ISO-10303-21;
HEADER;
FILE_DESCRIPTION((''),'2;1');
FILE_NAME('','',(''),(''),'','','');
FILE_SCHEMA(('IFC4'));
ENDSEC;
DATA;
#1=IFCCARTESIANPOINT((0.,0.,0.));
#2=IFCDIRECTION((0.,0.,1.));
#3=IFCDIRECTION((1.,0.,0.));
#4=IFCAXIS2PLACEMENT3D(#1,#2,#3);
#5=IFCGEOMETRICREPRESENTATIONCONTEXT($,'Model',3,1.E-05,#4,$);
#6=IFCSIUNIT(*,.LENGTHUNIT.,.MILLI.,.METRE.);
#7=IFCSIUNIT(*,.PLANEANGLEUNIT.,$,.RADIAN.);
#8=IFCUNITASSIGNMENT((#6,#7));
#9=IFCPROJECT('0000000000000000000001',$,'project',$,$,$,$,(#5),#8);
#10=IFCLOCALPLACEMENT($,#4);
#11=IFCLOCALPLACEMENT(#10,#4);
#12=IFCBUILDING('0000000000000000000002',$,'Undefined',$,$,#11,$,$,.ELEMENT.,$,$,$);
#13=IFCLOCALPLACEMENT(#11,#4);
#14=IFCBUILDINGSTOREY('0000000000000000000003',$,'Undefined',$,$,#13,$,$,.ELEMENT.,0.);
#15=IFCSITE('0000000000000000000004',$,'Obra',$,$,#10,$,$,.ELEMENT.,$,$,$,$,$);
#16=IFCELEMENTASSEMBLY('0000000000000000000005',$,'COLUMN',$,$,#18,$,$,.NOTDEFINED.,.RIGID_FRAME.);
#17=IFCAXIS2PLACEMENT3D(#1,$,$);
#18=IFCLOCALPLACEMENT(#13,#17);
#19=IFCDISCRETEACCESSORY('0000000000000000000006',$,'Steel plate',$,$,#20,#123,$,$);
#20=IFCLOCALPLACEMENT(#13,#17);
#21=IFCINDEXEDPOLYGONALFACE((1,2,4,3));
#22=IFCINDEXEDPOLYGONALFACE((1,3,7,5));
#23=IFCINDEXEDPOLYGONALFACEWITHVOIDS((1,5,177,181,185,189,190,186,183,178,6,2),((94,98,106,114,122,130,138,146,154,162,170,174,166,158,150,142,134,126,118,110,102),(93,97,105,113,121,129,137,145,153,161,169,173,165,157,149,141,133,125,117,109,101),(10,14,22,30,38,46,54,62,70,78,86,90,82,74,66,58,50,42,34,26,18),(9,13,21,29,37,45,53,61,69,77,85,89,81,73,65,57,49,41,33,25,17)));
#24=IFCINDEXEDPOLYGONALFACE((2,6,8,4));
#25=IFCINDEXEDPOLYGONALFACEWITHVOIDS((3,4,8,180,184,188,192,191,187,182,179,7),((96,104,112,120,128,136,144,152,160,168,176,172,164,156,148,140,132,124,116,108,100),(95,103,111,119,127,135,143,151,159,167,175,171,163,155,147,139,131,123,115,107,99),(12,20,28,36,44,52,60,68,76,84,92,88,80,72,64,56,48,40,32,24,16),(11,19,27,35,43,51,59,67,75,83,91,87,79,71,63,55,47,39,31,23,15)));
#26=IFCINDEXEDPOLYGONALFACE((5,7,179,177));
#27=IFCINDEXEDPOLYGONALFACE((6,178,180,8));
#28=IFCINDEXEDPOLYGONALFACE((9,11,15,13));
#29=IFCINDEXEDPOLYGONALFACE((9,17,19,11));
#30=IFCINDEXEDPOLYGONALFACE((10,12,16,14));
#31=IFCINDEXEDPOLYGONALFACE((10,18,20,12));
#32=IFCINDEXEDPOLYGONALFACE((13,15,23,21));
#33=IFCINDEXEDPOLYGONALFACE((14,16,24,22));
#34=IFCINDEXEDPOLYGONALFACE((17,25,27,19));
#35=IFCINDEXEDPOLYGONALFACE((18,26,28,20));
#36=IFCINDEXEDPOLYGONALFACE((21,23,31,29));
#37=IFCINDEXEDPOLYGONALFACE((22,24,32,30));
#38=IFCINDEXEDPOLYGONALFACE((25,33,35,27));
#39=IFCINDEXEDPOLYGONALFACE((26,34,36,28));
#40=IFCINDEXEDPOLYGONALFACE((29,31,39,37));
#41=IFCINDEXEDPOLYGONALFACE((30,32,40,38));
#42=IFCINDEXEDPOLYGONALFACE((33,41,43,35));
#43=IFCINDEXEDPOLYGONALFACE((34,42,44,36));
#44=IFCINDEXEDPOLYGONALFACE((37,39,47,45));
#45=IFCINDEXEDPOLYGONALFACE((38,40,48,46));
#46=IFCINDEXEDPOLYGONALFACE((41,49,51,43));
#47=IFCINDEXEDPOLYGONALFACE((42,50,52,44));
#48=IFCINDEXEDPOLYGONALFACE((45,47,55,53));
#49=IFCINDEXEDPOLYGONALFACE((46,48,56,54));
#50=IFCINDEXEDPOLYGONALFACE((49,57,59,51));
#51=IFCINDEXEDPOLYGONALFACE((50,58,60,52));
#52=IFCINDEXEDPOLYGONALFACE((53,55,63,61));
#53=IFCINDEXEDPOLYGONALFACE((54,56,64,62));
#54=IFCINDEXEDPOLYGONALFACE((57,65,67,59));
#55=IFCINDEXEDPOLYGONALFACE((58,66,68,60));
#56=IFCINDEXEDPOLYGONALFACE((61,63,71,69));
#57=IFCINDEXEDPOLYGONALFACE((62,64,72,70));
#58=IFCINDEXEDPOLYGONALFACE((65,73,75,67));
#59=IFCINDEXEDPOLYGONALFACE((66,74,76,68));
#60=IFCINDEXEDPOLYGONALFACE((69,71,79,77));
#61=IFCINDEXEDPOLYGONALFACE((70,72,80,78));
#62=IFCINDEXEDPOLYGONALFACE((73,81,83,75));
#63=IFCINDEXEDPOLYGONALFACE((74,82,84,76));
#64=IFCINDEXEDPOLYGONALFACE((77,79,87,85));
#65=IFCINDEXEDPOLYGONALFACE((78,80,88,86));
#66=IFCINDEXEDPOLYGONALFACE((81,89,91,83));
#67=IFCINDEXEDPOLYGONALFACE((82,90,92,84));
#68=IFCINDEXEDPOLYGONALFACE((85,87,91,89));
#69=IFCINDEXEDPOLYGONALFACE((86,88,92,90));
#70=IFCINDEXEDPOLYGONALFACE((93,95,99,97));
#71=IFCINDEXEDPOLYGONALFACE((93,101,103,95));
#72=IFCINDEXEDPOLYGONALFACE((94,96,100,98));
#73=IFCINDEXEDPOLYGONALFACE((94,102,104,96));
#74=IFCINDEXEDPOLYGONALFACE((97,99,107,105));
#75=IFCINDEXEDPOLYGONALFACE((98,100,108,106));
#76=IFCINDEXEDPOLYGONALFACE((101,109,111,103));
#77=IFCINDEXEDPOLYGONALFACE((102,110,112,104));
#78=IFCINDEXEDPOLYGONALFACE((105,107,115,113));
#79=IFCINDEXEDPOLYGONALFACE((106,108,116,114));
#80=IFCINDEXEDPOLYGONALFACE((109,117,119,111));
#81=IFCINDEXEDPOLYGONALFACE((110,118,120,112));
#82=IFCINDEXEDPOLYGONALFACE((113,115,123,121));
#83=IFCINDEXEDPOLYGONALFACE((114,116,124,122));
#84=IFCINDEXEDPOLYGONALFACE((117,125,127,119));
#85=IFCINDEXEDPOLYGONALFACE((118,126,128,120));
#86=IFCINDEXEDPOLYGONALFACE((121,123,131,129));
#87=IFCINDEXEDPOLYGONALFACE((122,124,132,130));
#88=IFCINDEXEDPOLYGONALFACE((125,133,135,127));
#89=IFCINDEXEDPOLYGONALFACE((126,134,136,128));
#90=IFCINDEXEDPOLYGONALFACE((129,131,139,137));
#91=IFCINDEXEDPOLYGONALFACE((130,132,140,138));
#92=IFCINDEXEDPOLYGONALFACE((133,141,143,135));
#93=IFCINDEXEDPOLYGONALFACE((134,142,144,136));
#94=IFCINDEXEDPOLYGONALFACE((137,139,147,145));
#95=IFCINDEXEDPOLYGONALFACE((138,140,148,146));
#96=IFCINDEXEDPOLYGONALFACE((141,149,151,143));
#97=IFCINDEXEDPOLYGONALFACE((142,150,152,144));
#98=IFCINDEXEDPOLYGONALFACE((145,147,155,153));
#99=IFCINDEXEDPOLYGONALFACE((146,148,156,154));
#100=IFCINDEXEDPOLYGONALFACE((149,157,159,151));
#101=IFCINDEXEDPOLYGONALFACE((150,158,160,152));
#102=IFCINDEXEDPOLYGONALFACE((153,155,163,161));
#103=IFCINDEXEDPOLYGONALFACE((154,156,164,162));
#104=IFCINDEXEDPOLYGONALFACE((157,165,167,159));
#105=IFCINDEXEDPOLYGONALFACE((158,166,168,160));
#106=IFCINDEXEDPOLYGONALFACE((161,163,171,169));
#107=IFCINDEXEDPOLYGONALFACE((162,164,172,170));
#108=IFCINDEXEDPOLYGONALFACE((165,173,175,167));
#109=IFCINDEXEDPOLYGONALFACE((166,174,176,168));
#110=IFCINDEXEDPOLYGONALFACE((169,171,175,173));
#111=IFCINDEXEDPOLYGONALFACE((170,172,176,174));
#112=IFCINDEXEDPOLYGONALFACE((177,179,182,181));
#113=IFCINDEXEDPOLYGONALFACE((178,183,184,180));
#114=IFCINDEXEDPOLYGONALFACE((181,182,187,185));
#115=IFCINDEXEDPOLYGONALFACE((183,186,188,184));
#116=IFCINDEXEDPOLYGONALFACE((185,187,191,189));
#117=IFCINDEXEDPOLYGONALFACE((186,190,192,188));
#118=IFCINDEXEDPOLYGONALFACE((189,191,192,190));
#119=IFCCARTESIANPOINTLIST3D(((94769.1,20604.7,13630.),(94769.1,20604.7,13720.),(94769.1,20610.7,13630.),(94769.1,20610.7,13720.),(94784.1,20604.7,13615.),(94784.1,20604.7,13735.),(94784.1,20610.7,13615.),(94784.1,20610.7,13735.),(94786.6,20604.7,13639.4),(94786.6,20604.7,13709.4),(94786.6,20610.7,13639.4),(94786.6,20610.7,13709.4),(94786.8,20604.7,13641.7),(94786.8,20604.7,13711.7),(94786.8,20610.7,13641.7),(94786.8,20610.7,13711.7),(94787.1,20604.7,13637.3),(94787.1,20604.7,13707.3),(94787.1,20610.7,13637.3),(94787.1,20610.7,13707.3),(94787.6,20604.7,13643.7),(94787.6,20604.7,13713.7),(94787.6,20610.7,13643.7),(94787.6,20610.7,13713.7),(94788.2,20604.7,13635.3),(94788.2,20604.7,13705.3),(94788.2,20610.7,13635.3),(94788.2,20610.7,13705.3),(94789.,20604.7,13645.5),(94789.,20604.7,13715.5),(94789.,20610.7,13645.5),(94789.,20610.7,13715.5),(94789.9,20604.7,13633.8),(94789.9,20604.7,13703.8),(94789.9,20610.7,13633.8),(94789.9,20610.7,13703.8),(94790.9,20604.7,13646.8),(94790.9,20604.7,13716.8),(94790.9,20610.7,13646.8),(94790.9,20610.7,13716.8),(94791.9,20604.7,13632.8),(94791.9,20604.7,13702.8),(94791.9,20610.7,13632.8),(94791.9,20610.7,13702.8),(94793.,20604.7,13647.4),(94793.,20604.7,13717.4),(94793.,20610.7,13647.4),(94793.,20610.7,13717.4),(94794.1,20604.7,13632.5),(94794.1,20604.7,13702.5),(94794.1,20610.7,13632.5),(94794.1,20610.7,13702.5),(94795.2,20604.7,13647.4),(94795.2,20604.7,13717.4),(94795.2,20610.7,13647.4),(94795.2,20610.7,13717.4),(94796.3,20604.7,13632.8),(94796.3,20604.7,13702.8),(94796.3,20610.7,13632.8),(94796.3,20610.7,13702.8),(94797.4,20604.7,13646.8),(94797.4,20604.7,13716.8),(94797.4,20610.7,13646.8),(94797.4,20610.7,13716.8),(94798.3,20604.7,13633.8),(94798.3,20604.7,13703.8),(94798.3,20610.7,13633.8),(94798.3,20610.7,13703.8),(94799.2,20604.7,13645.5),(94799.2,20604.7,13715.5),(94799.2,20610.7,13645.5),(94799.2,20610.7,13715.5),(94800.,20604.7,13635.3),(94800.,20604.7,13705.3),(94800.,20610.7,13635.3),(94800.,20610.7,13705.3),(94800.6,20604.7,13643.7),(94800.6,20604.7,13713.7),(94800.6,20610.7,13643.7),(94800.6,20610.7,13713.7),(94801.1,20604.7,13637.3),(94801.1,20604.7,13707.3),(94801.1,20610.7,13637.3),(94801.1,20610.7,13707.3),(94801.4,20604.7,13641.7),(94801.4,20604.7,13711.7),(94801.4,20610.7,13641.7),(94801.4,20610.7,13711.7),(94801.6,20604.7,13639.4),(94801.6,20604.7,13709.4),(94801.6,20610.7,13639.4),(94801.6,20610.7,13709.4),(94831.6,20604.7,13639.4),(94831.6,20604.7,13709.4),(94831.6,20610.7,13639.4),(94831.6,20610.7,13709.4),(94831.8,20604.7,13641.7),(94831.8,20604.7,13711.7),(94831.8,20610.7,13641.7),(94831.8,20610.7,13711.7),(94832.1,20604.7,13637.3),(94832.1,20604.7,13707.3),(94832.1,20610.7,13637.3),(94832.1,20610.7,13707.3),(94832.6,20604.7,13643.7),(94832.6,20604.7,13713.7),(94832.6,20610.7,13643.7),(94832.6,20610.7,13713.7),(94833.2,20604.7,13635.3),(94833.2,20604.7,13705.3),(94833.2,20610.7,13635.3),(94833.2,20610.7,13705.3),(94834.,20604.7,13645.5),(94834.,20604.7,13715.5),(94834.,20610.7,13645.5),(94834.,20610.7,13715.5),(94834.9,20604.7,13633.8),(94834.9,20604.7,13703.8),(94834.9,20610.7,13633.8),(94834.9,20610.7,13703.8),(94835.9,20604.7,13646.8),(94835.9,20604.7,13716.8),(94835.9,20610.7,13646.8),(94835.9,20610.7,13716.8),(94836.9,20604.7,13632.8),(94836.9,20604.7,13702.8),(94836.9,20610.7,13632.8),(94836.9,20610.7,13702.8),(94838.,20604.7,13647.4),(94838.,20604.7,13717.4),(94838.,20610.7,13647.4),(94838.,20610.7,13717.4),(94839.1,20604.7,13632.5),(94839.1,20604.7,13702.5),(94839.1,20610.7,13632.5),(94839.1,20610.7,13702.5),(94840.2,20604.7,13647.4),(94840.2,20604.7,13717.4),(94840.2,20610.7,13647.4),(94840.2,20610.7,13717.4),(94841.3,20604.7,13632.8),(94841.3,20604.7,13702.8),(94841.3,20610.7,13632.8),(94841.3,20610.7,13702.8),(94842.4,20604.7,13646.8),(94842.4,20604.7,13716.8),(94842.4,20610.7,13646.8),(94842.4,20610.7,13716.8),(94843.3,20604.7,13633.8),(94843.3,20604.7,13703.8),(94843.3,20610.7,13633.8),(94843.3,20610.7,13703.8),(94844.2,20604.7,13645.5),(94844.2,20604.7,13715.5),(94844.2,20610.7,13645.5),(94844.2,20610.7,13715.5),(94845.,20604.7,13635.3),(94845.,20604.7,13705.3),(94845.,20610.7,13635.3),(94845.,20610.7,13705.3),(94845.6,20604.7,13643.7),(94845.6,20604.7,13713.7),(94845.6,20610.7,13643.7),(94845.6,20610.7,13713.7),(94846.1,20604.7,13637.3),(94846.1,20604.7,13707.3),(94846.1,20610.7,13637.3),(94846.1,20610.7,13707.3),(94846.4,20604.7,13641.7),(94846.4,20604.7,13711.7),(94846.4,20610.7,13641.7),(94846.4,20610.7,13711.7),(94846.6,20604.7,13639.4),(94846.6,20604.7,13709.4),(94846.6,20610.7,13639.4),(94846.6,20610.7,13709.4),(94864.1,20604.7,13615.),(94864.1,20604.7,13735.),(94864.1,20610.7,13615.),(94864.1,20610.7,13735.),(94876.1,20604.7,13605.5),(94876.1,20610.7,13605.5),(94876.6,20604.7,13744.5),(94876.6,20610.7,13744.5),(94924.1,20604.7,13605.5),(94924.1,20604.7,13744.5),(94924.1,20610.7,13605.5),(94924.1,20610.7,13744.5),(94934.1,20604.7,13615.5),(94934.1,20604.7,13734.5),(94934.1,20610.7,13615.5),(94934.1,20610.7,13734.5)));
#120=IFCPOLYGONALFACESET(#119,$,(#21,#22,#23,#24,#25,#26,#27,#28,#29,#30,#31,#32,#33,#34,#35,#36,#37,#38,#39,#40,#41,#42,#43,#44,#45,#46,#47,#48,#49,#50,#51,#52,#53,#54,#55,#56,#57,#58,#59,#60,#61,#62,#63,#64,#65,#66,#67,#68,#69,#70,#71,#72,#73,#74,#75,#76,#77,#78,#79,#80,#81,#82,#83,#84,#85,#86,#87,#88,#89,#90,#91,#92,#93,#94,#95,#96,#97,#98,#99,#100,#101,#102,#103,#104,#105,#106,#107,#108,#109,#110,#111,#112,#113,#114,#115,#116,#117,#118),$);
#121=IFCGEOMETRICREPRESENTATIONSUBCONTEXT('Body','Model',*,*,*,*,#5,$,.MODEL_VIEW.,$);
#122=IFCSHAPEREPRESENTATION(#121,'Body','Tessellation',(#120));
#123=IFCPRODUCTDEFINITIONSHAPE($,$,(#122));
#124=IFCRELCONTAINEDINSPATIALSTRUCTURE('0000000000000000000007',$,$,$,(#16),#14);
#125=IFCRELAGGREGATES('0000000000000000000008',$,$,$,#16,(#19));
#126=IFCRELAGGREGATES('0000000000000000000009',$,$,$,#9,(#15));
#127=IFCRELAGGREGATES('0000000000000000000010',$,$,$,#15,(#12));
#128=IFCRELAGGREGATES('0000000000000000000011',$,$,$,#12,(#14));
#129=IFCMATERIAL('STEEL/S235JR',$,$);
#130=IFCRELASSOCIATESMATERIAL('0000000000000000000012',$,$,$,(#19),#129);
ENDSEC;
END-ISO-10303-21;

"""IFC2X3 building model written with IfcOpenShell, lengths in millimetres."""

from ifc_helpers import new_model, si_unit, frame, origin_with_axes, origin_2d_with_axis, place, context, subcontext, project, spatial, polyline, circle, outline, extrude, source, transform, mapped, material, element, aggregate, save


model = new_model("IFC2X3")

# Units and contexts
model_context = context("Model", 3, precision=1e-05, world=origin_with_axes())
body_context = subcontext(model_context, "Body", "Model", "MODEL_VIEW")
ifc_project = project(units=[si_unit("LENGTHUNIT", "METRE", prefix="MILLI"), si_unit("PLANEANGLEUNIT", "RADIAN")], contexts=[model_context])

# Site, building, storey
site_placement = place(None, origin_with_axes())
site = spatial("IfcSite", under=ifc_project, at=site_placement, Name="Obra", CompositionType="ELEMENT")
building_placement = place(site_placement, origin_with_axes())
building = spatial("IfcBuilding", under=site, at=building_placement, Name="Undefined", CompositionType="ELEMENT")
storey_placement = place(building_placement, origin_with_axes())
storey = spatial("IfcBuildingStorey", under=building, at=storey_placement, Name="Undefined", CompositionType="ELEMENT", Elevation=0.0)

# Shared definitions
ifc_material_1 = material(Name="STEEL/S235JR")

# Element assembly, discrete accessory, opening
assembly_1_placement = place(storey_placement, origin_with_axes())
assembly_1 = element("IfcElementAssembly", 1, at=assembly_1_placement, inside=storey, Name="COLUMN", AssemblyPlace="NOTDEFINED", PredefinedType="RIGID_FRAME")
shared_shape_1 = source(origin_with_axes(), body_context, "Body", "SweptSolid", [
    extrude(circle(Radius=7.5, at=origin_2d_with_axis()), frame((0.0, 2.4, 0.0), z_axis=(0.0, 1.0, 0.0), x_axis=(1.0, 0.0, 0.0)), (0.0, 0.0, 1.0), 6.2),
])
discrete_accessory_1_placement = place(assembly_1_placement, frame((94934.1, 20607.7, 13615.5), z_axis=(0.0, 1.0, 0.0), x_axis=(-0.707107, 0.0, -0.707107)))
discrete_accessory_1 = element("IfcDiscreteAccessory", 2, at=discrete_accessory_1_placement, material=ifc_material_1, Name="Steel plate", context=body_context, shape_type="SweptSolid", body=[
    extrude(outline(polyline([(0.0, 0.0), (14.1, 0.0), (48.1, 33.9), (49.9, 49.1), (106.4, 105.7), (106.4, 126.9), (42.8, 190.6), (21.6, 190.6), (-35.0, 134.0), (-50.6, 131.9), (-84.1, 98.3), (-84.1, 84.1), (0.0, 0.0)])), frame((0.0, 0.0, -3.0), z_axis=(0.0, 0.0, 1.0), x_axis=(1.0, 0.0, 0.0)), (0.0, 0.0, 1.0), 6.0),
])
opening_1_placement = place(assembly_1_placement, frame((94816.6, 20613.2, 13710.0), z_axis=(-1.0, 0.0, 0.0), x_axis=(0.0, 0.0, -1.0)))
element("IfcOpeningElement", 3, at=opening_1_placement, cuts=discrete_accessory_1, ObjectType="Opening", context=body_context, shape_type="MappedRepresentation", body=[
    mapped(shared_shape_1, transform((0.0, 0.0, -22.5))),
    mapped(shared_shape_1, transform((70.0, 0.0, -22.5))),
    mapped(shared_shape_1, transform((0.0, 0.0, 22.5))),
    mapped(shared_shape_1, transform((70.0, 0.0, 22.5))),
])
aggregate(assembly_1, [discrete_accessory_1])

save(model, "model.ifc")
